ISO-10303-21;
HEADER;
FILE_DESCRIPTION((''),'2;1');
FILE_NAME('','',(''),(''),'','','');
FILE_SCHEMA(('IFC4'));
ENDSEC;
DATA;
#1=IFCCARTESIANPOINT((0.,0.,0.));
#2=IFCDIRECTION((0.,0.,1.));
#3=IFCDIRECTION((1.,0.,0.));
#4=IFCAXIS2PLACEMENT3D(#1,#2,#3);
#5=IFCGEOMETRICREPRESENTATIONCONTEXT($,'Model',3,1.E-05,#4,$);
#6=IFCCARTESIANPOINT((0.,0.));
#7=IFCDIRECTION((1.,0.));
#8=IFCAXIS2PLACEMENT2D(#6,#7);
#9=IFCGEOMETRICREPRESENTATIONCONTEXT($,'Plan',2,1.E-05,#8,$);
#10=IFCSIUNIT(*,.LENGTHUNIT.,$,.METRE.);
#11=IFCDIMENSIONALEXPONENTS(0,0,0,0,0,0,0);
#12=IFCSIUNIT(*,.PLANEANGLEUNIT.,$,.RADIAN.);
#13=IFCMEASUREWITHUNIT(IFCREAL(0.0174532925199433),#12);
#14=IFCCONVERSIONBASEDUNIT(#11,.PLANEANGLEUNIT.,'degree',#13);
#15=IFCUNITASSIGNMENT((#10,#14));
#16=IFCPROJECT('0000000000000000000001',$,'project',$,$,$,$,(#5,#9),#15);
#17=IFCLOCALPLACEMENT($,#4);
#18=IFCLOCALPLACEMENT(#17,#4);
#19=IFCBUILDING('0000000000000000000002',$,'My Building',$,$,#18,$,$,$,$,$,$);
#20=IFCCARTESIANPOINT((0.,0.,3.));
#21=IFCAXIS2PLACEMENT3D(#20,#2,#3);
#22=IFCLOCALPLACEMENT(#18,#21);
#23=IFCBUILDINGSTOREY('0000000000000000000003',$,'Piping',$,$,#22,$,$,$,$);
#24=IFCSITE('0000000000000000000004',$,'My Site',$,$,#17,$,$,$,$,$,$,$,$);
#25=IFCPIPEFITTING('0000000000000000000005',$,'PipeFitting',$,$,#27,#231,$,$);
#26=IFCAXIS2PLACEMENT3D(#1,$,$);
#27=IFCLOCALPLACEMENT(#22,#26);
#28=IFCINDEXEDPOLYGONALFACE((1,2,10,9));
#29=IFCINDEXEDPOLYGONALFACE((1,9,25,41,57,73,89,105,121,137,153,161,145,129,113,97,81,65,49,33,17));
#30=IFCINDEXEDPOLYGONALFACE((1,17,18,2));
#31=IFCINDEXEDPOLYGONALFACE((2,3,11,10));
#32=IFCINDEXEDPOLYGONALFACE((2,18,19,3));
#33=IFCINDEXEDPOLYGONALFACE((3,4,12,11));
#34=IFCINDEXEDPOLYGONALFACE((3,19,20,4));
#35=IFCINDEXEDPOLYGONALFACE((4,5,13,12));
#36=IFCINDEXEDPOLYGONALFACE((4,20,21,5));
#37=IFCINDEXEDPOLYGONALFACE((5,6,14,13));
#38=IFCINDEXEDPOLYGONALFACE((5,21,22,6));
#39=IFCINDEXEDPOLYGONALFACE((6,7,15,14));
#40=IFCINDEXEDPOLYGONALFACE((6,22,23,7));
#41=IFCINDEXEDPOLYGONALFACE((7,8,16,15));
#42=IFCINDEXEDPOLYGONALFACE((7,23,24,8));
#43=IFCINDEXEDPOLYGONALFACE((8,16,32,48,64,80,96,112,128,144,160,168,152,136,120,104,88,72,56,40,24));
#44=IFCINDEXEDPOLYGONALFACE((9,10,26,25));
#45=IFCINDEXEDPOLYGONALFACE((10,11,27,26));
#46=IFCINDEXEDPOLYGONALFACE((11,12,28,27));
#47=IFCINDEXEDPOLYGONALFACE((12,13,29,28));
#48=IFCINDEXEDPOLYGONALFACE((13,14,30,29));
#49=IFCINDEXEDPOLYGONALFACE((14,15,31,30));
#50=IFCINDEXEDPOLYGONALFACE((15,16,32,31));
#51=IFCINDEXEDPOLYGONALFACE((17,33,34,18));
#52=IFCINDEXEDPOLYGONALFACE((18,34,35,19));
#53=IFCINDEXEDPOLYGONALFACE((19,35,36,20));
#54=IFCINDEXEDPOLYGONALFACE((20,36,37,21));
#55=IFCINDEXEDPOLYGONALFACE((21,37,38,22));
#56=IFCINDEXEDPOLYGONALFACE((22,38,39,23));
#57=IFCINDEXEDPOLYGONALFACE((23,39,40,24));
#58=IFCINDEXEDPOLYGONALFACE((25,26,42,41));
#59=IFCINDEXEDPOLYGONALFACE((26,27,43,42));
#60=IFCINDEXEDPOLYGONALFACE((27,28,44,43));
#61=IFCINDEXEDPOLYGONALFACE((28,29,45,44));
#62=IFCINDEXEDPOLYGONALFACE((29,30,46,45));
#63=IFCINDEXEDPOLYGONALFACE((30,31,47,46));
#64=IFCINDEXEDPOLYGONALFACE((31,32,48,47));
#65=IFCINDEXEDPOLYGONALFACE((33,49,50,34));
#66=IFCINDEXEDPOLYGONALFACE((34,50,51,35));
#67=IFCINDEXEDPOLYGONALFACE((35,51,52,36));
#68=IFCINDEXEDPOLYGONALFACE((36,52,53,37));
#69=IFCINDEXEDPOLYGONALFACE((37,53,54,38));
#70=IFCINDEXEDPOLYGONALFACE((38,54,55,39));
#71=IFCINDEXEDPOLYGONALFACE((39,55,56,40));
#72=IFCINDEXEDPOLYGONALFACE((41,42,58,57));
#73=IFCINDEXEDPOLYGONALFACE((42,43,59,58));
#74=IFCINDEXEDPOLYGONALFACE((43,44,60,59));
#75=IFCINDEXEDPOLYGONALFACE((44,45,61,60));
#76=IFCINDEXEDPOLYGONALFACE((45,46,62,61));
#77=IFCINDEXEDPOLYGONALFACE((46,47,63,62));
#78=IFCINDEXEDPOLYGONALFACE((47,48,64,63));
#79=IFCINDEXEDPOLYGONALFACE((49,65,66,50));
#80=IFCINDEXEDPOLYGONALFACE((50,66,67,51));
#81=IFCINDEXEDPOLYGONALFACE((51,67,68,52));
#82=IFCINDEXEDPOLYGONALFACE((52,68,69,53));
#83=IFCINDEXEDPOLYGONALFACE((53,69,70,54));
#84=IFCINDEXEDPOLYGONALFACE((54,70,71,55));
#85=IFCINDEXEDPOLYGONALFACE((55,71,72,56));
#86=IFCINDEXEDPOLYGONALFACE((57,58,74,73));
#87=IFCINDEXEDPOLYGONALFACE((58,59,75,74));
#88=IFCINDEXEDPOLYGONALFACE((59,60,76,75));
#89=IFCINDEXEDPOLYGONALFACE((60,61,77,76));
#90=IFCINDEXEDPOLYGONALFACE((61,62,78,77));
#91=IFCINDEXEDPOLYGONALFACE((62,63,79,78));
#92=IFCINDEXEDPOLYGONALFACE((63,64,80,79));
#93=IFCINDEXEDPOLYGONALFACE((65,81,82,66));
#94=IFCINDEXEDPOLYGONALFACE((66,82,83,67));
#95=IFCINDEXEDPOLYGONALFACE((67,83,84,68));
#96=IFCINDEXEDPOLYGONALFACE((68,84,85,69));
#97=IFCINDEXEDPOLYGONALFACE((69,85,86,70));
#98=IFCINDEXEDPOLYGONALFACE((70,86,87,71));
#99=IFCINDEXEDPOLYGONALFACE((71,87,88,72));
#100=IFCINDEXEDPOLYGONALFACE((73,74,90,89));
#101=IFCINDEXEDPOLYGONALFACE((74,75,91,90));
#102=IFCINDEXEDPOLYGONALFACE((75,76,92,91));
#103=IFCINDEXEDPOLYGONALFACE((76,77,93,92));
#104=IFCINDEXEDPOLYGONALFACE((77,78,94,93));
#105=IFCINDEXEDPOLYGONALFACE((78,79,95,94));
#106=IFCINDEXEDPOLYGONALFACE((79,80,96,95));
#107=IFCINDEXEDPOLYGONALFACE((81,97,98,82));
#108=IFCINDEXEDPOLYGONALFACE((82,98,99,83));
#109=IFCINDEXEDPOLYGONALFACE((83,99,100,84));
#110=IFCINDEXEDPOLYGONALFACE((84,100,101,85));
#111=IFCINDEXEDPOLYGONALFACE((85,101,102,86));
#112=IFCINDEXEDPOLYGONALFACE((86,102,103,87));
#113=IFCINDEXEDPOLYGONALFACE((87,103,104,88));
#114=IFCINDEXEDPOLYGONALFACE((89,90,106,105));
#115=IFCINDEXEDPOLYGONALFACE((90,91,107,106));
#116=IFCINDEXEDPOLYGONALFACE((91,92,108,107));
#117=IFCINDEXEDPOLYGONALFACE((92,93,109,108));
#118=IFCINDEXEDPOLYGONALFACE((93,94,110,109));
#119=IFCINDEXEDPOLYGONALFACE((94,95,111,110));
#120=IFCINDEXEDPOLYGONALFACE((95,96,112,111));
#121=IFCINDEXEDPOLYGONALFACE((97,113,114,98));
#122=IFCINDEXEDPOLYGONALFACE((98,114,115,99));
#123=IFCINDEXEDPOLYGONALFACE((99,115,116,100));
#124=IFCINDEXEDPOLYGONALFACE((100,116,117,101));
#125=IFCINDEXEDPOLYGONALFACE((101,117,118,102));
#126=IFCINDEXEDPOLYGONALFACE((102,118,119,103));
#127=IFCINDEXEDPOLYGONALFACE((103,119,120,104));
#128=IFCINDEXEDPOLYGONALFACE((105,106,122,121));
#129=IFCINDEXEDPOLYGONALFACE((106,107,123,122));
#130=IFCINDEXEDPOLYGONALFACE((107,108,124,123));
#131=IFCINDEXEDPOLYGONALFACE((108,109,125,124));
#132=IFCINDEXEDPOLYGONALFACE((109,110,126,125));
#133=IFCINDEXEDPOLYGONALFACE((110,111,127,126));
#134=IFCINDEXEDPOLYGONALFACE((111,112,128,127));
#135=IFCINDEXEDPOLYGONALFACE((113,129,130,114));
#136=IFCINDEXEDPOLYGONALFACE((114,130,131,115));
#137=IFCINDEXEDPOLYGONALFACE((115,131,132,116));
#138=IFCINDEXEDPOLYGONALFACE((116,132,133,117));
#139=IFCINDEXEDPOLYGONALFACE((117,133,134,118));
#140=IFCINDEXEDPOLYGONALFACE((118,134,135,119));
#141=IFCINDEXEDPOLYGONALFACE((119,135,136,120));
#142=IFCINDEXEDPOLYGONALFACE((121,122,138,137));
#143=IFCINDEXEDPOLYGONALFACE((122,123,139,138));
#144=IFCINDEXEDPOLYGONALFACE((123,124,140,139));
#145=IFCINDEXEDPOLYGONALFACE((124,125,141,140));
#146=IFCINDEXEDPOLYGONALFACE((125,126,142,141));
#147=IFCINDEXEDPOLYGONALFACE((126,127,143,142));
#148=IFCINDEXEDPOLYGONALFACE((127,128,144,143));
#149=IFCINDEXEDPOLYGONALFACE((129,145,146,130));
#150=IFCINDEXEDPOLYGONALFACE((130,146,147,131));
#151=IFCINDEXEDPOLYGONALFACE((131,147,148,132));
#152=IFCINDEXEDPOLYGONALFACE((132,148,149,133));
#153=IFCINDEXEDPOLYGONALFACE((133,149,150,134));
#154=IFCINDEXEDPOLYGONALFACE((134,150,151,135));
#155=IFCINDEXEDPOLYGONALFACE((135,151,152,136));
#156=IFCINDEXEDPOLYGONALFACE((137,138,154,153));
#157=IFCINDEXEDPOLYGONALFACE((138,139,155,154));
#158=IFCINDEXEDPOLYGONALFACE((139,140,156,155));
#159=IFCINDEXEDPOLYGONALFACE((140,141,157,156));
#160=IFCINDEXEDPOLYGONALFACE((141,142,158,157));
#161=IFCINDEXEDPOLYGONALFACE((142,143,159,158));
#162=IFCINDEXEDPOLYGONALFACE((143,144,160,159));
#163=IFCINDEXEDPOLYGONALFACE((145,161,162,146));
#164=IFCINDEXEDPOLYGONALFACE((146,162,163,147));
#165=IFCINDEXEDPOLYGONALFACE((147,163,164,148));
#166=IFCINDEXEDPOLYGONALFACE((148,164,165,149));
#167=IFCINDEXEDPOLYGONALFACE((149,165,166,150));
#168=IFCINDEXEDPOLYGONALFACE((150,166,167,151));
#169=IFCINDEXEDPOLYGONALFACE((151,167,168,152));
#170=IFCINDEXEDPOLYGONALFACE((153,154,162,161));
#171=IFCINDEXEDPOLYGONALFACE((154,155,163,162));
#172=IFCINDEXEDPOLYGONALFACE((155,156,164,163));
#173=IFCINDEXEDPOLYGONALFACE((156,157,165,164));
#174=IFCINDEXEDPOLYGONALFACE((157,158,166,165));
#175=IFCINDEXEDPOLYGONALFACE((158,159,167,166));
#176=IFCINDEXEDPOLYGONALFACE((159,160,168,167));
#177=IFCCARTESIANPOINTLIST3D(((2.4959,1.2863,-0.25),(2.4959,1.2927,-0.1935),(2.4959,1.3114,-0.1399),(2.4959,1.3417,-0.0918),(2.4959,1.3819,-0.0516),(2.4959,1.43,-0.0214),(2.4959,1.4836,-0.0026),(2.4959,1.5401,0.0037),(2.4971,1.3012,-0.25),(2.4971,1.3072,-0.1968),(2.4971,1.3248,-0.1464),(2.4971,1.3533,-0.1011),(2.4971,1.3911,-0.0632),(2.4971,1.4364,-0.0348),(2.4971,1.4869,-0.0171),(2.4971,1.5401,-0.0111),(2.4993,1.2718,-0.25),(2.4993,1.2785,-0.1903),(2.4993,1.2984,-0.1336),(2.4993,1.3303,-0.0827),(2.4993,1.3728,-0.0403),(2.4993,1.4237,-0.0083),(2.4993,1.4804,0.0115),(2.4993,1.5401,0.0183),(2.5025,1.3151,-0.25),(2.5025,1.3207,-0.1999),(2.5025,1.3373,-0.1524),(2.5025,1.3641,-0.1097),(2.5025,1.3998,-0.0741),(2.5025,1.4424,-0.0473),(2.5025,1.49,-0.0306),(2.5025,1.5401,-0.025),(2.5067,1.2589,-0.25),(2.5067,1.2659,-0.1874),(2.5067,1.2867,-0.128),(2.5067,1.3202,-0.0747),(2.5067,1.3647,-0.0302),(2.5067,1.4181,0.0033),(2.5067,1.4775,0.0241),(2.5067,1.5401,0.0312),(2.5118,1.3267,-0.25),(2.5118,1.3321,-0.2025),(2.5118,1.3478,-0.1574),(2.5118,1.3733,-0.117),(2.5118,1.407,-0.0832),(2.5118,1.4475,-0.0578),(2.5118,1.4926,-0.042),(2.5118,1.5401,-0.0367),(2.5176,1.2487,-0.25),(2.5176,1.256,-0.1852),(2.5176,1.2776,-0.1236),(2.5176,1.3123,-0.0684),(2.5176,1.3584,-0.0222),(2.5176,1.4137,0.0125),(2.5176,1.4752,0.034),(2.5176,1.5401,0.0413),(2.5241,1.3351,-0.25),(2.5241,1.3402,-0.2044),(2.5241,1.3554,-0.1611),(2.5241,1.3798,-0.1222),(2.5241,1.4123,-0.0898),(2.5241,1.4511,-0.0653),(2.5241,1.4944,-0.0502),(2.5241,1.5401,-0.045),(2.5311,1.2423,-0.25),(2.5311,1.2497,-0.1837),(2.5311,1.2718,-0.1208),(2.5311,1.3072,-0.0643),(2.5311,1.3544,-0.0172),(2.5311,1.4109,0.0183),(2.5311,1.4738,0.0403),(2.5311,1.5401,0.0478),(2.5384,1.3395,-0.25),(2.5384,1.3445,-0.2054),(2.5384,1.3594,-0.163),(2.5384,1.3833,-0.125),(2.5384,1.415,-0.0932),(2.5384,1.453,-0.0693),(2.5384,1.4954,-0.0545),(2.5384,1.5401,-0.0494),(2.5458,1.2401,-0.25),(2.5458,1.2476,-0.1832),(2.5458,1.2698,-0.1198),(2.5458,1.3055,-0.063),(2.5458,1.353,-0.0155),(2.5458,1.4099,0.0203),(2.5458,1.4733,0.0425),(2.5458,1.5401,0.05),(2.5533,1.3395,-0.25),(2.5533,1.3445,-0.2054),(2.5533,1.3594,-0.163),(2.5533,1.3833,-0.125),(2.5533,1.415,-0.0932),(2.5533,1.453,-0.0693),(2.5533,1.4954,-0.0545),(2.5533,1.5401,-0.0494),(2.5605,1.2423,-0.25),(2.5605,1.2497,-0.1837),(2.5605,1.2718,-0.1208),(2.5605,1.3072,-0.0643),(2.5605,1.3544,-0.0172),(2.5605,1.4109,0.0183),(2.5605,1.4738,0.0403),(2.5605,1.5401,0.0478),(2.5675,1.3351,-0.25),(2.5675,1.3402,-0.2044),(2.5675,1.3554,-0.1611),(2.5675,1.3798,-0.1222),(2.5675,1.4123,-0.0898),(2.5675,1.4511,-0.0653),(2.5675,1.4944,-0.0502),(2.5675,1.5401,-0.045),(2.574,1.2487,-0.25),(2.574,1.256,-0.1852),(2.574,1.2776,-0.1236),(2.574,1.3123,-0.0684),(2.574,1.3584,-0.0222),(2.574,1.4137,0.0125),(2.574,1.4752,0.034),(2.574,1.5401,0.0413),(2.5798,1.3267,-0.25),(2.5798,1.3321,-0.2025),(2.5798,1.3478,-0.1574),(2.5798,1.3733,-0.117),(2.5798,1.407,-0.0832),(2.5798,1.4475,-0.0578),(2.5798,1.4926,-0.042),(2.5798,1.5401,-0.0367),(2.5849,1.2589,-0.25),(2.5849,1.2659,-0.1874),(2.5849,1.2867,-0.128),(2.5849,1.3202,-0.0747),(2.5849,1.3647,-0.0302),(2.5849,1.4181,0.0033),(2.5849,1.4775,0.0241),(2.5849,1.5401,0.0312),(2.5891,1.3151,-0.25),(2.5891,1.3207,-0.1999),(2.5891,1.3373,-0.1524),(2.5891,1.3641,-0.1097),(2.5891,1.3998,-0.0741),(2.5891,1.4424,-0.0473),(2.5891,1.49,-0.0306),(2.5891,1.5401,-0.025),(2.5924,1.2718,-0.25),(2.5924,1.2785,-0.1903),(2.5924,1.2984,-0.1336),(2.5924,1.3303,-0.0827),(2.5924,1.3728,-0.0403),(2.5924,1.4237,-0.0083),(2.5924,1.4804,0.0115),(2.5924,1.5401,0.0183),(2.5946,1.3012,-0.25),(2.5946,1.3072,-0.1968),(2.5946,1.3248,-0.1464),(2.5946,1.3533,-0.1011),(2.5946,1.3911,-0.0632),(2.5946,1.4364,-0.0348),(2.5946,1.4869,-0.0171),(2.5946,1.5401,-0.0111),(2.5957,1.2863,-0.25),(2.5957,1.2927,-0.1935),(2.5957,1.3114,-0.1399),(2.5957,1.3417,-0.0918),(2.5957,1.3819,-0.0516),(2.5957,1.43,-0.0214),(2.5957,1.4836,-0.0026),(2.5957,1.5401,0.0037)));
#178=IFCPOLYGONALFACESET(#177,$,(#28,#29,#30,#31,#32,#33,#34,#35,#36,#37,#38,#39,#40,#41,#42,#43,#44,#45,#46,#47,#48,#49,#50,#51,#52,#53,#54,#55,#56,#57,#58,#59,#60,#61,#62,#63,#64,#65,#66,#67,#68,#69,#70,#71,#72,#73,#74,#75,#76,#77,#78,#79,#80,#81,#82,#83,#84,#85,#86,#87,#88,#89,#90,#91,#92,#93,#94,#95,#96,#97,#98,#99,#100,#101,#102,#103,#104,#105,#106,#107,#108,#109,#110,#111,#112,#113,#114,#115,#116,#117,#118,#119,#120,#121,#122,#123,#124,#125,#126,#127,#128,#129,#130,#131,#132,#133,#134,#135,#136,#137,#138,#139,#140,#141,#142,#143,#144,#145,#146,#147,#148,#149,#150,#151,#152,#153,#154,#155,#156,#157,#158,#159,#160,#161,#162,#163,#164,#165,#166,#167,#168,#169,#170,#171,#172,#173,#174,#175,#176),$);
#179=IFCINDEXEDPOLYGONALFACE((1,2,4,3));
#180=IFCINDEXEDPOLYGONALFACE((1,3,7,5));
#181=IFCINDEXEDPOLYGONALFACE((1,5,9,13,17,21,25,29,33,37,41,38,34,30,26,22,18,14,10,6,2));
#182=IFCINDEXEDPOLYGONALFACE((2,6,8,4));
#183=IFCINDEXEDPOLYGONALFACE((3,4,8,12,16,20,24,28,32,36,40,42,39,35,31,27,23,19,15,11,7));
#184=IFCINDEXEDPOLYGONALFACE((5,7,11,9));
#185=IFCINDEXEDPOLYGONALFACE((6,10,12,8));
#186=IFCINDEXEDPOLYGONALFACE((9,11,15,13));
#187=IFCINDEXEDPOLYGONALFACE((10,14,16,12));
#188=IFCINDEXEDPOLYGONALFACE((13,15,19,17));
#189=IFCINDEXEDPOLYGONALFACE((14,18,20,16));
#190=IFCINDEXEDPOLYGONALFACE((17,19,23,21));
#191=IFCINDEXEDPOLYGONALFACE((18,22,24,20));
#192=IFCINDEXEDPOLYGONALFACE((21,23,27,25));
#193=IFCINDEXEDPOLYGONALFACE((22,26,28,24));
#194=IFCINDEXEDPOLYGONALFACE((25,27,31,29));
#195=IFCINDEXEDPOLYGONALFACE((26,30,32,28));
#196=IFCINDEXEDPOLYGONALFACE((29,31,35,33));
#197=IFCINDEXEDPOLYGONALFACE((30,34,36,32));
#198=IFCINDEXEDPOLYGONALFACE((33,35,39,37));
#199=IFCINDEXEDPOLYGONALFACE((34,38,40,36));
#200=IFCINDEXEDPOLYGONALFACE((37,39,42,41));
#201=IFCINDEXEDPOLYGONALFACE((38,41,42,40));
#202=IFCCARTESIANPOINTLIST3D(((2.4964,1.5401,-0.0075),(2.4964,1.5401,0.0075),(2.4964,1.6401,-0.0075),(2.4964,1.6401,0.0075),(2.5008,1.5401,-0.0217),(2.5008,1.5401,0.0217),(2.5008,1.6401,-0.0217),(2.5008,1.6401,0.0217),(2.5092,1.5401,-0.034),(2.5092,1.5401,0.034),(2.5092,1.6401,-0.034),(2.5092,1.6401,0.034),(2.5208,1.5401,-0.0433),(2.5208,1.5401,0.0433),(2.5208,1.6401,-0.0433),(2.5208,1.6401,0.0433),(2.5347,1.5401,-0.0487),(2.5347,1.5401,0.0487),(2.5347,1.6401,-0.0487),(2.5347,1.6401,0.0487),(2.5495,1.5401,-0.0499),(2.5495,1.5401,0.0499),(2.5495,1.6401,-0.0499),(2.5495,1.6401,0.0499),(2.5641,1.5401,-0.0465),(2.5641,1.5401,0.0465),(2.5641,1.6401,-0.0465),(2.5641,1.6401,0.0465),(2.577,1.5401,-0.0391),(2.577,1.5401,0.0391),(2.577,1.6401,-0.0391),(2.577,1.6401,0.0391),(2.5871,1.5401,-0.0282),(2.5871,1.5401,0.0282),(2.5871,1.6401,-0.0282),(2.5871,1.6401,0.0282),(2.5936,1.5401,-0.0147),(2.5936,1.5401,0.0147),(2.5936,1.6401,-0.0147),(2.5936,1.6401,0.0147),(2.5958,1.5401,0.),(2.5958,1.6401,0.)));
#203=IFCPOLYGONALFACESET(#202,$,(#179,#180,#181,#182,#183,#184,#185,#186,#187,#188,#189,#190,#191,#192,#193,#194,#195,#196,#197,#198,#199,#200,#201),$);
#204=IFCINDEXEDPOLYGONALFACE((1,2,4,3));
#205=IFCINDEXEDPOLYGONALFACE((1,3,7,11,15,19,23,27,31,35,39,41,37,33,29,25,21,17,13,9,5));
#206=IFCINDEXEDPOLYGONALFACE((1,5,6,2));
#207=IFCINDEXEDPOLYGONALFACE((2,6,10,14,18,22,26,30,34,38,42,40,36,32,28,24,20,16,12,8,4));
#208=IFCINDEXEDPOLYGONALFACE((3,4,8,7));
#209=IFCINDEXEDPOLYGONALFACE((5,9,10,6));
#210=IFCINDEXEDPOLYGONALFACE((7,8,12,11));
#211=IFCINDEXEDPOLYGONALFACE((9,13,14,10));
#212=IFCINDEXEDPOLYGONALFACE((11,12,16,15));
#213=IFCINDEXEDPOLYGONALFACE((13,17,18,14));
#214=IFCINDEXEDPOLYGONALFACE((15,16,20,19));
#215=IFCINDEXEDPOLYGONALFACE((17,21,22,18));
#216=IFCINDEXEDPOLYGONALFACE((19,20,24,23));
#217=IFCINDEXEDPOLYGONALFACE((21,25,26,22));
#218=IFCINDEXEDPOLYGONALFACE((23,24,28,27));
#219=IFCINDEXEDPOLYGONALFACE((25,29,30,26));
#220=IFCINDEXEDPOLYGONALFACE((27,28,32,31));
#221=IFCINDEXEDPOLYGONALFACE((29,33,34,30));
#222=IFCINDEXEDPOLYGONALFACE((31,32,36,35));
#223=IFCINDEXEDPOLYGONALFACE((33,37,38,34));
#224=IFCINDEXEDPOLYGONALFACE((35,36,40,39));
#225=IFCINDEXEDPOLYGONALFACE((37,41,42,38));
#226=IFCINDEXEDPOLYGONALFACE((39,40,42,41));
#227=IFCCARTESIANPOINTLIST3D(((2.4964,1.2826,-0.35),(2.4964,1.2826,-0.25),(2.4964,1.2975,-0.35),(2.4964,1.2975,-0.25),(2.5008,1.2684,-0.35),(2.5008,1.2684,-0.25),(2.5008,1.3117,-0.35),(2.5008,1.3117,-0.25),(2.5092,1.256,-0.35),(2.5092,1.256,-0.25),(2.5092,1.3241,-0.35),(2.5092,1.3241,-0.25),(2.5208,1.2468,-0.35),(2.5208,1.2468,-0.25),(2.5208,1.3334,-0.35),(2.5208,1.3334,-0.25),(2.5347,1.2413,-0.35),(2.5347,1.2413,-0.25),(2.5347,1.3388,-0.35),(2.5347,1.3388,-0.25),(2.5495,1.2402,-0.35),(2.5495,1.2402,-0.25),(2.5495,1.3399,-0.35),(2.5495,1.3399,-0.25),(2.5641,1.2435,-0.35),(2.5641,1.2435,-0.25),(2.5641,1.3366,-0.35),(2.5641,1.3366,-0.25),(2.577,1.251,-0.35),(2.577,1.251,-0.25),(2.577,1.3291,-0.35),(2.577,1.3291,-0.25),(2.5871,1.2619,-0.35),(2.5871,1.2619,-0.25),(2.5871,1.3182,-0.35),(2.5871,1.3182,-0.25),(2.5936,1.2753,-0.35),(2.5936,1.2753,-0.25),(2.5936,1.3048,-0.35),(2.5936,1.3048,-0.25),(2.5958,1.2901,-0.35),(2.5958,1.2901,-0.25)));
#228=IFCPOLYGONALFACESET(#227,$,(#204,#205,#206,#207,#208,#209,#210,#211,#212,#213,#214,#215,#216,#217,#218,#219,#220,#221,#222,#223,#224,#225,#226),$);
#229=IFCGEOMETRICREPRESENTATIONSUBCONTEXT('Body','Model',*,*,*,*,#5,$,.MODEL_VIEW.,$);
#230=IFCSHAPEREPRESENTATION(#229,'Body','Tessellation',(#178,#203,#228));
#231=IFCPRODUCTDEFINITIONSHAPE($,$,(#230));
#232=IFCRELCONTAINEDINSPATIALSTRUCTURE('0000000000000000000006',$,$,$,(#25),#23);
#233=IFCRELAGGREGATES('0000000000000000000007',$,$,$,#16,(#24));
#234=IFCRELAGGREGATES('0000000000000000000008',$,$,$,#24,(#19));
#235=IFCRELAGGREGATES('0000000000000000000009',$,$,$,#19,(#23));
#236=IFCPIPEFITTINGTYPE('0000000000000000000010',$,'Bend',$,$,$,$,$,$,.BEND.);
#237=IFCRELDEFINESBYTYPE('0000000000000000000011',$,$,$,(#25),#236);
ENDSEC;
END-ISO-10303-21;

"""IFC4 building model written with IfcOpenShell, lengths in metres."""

from ifc_helpers import new_model, entity, si_unit, converted_unit, frame, origin_with_axes, origin_2d_with_axis, place, context, subcontext, project, spatial, circle, extrude, source, transform, mapped, type_object, type_shapes, element, save


model = new_model("IFC4")

# Units and contexts
model_context = context("Model", 3, precision=1e-05, world=origin_with_axes())
plan_context = context("Plan", 2, precision=1e-05, world=origin_2d_with_axis())
body_context = subcontext(model_context, "Body", "Model", "MODEL_VIEW")
ifc_project = project(units=[si_unit("LENGTHUNIT", "METRE"), converted_unit("PLANEANGLEUNIT", "degree", entity("IfcReal", 0.0174532925199433), si_unit("PLANEANGLEUNIT", "RADIAN"), dimensions=[0, 0, 0, 0, 0, 0, 0])], contexts=[model_context, plan_context])

# Site, building, storey
site_placement = place(None, origin_with_axes())
site = spatial("IfcSite", under=ifc_project, at=site_placement, Name="My Site")
building_placement = place(site_placement, origin_with_axes())
building = spatial("IfcBuilding", under=site, at=building_placement, Name="My Building")
storey_placement = place(building_placement, frame((0.0, 0.0, 3.0), z_axis=(0.0, 0.0, 1.0), x_axis=(1.0, 0.0, 0.0)))
storey = spatial("IfcBuildingStorey", under=building, at=storey_placement, Name="Piping")

# Pipe fitting
pipe_fitting_type_1 = type_object("IfcPipeFittingType", Name="Bend", PredefinedType="BEND")
shared_shape = source(origin_with_axes(), body_context, "Body", "SolidModel", [
    entity("IfcSweptDiskSolid", entity("IfcIndexedPolyCurve", entity("IfcCartesianPointList3D", [[0.0, 0.0, -0.1], [0.0, 0.0732, -0.2768], [0.0, 0.25, -0.35]]), [entity("IfcArcIndex", [1, 2, 3])]), 0.05),
    extrude(circle(Radius=0.05), origin_with_axes(), (0.0, 0.0, -1.0), 0.1),
    extrude(circle(Radius=0.05), frame((0.0, 0.25, -0.35), z_axis=(0.0, 1.0, 0.0), x_axis=(1.0, 0.0, 0.0)), (0.0, 0.0, 1.0), 0.1),
])
type_shapes(pipe_fitting_type_1, [shared_shape])
for number, where, z_axis, x_axis, name in (
    (1, (2.5458, 1.6401, 0.0), (0.0, 1.0, 0.0), (1.0, 0.0, 0.0), "PipeFitting"),
):
    element("IfcPipeFitting", number, at=place(storey_placement, frame(where, z_axis=z_axis, x_axis=x_axis)), inside=storey, type_object=pipe_fitting_type_1, Name=name, context=body_context, shape_type="MappedRepresentation", body=[
        mapped(shared_shape, transform((0.0, 0.0, 0.0), x_axis=(1.0, 0.0, 0.0), y_axis=(0.0, 1.0, 0.0), z_axis=(0.0, 0.0, 1.0), scale=1.0)),
    ])

save(model, "model.ifc")
